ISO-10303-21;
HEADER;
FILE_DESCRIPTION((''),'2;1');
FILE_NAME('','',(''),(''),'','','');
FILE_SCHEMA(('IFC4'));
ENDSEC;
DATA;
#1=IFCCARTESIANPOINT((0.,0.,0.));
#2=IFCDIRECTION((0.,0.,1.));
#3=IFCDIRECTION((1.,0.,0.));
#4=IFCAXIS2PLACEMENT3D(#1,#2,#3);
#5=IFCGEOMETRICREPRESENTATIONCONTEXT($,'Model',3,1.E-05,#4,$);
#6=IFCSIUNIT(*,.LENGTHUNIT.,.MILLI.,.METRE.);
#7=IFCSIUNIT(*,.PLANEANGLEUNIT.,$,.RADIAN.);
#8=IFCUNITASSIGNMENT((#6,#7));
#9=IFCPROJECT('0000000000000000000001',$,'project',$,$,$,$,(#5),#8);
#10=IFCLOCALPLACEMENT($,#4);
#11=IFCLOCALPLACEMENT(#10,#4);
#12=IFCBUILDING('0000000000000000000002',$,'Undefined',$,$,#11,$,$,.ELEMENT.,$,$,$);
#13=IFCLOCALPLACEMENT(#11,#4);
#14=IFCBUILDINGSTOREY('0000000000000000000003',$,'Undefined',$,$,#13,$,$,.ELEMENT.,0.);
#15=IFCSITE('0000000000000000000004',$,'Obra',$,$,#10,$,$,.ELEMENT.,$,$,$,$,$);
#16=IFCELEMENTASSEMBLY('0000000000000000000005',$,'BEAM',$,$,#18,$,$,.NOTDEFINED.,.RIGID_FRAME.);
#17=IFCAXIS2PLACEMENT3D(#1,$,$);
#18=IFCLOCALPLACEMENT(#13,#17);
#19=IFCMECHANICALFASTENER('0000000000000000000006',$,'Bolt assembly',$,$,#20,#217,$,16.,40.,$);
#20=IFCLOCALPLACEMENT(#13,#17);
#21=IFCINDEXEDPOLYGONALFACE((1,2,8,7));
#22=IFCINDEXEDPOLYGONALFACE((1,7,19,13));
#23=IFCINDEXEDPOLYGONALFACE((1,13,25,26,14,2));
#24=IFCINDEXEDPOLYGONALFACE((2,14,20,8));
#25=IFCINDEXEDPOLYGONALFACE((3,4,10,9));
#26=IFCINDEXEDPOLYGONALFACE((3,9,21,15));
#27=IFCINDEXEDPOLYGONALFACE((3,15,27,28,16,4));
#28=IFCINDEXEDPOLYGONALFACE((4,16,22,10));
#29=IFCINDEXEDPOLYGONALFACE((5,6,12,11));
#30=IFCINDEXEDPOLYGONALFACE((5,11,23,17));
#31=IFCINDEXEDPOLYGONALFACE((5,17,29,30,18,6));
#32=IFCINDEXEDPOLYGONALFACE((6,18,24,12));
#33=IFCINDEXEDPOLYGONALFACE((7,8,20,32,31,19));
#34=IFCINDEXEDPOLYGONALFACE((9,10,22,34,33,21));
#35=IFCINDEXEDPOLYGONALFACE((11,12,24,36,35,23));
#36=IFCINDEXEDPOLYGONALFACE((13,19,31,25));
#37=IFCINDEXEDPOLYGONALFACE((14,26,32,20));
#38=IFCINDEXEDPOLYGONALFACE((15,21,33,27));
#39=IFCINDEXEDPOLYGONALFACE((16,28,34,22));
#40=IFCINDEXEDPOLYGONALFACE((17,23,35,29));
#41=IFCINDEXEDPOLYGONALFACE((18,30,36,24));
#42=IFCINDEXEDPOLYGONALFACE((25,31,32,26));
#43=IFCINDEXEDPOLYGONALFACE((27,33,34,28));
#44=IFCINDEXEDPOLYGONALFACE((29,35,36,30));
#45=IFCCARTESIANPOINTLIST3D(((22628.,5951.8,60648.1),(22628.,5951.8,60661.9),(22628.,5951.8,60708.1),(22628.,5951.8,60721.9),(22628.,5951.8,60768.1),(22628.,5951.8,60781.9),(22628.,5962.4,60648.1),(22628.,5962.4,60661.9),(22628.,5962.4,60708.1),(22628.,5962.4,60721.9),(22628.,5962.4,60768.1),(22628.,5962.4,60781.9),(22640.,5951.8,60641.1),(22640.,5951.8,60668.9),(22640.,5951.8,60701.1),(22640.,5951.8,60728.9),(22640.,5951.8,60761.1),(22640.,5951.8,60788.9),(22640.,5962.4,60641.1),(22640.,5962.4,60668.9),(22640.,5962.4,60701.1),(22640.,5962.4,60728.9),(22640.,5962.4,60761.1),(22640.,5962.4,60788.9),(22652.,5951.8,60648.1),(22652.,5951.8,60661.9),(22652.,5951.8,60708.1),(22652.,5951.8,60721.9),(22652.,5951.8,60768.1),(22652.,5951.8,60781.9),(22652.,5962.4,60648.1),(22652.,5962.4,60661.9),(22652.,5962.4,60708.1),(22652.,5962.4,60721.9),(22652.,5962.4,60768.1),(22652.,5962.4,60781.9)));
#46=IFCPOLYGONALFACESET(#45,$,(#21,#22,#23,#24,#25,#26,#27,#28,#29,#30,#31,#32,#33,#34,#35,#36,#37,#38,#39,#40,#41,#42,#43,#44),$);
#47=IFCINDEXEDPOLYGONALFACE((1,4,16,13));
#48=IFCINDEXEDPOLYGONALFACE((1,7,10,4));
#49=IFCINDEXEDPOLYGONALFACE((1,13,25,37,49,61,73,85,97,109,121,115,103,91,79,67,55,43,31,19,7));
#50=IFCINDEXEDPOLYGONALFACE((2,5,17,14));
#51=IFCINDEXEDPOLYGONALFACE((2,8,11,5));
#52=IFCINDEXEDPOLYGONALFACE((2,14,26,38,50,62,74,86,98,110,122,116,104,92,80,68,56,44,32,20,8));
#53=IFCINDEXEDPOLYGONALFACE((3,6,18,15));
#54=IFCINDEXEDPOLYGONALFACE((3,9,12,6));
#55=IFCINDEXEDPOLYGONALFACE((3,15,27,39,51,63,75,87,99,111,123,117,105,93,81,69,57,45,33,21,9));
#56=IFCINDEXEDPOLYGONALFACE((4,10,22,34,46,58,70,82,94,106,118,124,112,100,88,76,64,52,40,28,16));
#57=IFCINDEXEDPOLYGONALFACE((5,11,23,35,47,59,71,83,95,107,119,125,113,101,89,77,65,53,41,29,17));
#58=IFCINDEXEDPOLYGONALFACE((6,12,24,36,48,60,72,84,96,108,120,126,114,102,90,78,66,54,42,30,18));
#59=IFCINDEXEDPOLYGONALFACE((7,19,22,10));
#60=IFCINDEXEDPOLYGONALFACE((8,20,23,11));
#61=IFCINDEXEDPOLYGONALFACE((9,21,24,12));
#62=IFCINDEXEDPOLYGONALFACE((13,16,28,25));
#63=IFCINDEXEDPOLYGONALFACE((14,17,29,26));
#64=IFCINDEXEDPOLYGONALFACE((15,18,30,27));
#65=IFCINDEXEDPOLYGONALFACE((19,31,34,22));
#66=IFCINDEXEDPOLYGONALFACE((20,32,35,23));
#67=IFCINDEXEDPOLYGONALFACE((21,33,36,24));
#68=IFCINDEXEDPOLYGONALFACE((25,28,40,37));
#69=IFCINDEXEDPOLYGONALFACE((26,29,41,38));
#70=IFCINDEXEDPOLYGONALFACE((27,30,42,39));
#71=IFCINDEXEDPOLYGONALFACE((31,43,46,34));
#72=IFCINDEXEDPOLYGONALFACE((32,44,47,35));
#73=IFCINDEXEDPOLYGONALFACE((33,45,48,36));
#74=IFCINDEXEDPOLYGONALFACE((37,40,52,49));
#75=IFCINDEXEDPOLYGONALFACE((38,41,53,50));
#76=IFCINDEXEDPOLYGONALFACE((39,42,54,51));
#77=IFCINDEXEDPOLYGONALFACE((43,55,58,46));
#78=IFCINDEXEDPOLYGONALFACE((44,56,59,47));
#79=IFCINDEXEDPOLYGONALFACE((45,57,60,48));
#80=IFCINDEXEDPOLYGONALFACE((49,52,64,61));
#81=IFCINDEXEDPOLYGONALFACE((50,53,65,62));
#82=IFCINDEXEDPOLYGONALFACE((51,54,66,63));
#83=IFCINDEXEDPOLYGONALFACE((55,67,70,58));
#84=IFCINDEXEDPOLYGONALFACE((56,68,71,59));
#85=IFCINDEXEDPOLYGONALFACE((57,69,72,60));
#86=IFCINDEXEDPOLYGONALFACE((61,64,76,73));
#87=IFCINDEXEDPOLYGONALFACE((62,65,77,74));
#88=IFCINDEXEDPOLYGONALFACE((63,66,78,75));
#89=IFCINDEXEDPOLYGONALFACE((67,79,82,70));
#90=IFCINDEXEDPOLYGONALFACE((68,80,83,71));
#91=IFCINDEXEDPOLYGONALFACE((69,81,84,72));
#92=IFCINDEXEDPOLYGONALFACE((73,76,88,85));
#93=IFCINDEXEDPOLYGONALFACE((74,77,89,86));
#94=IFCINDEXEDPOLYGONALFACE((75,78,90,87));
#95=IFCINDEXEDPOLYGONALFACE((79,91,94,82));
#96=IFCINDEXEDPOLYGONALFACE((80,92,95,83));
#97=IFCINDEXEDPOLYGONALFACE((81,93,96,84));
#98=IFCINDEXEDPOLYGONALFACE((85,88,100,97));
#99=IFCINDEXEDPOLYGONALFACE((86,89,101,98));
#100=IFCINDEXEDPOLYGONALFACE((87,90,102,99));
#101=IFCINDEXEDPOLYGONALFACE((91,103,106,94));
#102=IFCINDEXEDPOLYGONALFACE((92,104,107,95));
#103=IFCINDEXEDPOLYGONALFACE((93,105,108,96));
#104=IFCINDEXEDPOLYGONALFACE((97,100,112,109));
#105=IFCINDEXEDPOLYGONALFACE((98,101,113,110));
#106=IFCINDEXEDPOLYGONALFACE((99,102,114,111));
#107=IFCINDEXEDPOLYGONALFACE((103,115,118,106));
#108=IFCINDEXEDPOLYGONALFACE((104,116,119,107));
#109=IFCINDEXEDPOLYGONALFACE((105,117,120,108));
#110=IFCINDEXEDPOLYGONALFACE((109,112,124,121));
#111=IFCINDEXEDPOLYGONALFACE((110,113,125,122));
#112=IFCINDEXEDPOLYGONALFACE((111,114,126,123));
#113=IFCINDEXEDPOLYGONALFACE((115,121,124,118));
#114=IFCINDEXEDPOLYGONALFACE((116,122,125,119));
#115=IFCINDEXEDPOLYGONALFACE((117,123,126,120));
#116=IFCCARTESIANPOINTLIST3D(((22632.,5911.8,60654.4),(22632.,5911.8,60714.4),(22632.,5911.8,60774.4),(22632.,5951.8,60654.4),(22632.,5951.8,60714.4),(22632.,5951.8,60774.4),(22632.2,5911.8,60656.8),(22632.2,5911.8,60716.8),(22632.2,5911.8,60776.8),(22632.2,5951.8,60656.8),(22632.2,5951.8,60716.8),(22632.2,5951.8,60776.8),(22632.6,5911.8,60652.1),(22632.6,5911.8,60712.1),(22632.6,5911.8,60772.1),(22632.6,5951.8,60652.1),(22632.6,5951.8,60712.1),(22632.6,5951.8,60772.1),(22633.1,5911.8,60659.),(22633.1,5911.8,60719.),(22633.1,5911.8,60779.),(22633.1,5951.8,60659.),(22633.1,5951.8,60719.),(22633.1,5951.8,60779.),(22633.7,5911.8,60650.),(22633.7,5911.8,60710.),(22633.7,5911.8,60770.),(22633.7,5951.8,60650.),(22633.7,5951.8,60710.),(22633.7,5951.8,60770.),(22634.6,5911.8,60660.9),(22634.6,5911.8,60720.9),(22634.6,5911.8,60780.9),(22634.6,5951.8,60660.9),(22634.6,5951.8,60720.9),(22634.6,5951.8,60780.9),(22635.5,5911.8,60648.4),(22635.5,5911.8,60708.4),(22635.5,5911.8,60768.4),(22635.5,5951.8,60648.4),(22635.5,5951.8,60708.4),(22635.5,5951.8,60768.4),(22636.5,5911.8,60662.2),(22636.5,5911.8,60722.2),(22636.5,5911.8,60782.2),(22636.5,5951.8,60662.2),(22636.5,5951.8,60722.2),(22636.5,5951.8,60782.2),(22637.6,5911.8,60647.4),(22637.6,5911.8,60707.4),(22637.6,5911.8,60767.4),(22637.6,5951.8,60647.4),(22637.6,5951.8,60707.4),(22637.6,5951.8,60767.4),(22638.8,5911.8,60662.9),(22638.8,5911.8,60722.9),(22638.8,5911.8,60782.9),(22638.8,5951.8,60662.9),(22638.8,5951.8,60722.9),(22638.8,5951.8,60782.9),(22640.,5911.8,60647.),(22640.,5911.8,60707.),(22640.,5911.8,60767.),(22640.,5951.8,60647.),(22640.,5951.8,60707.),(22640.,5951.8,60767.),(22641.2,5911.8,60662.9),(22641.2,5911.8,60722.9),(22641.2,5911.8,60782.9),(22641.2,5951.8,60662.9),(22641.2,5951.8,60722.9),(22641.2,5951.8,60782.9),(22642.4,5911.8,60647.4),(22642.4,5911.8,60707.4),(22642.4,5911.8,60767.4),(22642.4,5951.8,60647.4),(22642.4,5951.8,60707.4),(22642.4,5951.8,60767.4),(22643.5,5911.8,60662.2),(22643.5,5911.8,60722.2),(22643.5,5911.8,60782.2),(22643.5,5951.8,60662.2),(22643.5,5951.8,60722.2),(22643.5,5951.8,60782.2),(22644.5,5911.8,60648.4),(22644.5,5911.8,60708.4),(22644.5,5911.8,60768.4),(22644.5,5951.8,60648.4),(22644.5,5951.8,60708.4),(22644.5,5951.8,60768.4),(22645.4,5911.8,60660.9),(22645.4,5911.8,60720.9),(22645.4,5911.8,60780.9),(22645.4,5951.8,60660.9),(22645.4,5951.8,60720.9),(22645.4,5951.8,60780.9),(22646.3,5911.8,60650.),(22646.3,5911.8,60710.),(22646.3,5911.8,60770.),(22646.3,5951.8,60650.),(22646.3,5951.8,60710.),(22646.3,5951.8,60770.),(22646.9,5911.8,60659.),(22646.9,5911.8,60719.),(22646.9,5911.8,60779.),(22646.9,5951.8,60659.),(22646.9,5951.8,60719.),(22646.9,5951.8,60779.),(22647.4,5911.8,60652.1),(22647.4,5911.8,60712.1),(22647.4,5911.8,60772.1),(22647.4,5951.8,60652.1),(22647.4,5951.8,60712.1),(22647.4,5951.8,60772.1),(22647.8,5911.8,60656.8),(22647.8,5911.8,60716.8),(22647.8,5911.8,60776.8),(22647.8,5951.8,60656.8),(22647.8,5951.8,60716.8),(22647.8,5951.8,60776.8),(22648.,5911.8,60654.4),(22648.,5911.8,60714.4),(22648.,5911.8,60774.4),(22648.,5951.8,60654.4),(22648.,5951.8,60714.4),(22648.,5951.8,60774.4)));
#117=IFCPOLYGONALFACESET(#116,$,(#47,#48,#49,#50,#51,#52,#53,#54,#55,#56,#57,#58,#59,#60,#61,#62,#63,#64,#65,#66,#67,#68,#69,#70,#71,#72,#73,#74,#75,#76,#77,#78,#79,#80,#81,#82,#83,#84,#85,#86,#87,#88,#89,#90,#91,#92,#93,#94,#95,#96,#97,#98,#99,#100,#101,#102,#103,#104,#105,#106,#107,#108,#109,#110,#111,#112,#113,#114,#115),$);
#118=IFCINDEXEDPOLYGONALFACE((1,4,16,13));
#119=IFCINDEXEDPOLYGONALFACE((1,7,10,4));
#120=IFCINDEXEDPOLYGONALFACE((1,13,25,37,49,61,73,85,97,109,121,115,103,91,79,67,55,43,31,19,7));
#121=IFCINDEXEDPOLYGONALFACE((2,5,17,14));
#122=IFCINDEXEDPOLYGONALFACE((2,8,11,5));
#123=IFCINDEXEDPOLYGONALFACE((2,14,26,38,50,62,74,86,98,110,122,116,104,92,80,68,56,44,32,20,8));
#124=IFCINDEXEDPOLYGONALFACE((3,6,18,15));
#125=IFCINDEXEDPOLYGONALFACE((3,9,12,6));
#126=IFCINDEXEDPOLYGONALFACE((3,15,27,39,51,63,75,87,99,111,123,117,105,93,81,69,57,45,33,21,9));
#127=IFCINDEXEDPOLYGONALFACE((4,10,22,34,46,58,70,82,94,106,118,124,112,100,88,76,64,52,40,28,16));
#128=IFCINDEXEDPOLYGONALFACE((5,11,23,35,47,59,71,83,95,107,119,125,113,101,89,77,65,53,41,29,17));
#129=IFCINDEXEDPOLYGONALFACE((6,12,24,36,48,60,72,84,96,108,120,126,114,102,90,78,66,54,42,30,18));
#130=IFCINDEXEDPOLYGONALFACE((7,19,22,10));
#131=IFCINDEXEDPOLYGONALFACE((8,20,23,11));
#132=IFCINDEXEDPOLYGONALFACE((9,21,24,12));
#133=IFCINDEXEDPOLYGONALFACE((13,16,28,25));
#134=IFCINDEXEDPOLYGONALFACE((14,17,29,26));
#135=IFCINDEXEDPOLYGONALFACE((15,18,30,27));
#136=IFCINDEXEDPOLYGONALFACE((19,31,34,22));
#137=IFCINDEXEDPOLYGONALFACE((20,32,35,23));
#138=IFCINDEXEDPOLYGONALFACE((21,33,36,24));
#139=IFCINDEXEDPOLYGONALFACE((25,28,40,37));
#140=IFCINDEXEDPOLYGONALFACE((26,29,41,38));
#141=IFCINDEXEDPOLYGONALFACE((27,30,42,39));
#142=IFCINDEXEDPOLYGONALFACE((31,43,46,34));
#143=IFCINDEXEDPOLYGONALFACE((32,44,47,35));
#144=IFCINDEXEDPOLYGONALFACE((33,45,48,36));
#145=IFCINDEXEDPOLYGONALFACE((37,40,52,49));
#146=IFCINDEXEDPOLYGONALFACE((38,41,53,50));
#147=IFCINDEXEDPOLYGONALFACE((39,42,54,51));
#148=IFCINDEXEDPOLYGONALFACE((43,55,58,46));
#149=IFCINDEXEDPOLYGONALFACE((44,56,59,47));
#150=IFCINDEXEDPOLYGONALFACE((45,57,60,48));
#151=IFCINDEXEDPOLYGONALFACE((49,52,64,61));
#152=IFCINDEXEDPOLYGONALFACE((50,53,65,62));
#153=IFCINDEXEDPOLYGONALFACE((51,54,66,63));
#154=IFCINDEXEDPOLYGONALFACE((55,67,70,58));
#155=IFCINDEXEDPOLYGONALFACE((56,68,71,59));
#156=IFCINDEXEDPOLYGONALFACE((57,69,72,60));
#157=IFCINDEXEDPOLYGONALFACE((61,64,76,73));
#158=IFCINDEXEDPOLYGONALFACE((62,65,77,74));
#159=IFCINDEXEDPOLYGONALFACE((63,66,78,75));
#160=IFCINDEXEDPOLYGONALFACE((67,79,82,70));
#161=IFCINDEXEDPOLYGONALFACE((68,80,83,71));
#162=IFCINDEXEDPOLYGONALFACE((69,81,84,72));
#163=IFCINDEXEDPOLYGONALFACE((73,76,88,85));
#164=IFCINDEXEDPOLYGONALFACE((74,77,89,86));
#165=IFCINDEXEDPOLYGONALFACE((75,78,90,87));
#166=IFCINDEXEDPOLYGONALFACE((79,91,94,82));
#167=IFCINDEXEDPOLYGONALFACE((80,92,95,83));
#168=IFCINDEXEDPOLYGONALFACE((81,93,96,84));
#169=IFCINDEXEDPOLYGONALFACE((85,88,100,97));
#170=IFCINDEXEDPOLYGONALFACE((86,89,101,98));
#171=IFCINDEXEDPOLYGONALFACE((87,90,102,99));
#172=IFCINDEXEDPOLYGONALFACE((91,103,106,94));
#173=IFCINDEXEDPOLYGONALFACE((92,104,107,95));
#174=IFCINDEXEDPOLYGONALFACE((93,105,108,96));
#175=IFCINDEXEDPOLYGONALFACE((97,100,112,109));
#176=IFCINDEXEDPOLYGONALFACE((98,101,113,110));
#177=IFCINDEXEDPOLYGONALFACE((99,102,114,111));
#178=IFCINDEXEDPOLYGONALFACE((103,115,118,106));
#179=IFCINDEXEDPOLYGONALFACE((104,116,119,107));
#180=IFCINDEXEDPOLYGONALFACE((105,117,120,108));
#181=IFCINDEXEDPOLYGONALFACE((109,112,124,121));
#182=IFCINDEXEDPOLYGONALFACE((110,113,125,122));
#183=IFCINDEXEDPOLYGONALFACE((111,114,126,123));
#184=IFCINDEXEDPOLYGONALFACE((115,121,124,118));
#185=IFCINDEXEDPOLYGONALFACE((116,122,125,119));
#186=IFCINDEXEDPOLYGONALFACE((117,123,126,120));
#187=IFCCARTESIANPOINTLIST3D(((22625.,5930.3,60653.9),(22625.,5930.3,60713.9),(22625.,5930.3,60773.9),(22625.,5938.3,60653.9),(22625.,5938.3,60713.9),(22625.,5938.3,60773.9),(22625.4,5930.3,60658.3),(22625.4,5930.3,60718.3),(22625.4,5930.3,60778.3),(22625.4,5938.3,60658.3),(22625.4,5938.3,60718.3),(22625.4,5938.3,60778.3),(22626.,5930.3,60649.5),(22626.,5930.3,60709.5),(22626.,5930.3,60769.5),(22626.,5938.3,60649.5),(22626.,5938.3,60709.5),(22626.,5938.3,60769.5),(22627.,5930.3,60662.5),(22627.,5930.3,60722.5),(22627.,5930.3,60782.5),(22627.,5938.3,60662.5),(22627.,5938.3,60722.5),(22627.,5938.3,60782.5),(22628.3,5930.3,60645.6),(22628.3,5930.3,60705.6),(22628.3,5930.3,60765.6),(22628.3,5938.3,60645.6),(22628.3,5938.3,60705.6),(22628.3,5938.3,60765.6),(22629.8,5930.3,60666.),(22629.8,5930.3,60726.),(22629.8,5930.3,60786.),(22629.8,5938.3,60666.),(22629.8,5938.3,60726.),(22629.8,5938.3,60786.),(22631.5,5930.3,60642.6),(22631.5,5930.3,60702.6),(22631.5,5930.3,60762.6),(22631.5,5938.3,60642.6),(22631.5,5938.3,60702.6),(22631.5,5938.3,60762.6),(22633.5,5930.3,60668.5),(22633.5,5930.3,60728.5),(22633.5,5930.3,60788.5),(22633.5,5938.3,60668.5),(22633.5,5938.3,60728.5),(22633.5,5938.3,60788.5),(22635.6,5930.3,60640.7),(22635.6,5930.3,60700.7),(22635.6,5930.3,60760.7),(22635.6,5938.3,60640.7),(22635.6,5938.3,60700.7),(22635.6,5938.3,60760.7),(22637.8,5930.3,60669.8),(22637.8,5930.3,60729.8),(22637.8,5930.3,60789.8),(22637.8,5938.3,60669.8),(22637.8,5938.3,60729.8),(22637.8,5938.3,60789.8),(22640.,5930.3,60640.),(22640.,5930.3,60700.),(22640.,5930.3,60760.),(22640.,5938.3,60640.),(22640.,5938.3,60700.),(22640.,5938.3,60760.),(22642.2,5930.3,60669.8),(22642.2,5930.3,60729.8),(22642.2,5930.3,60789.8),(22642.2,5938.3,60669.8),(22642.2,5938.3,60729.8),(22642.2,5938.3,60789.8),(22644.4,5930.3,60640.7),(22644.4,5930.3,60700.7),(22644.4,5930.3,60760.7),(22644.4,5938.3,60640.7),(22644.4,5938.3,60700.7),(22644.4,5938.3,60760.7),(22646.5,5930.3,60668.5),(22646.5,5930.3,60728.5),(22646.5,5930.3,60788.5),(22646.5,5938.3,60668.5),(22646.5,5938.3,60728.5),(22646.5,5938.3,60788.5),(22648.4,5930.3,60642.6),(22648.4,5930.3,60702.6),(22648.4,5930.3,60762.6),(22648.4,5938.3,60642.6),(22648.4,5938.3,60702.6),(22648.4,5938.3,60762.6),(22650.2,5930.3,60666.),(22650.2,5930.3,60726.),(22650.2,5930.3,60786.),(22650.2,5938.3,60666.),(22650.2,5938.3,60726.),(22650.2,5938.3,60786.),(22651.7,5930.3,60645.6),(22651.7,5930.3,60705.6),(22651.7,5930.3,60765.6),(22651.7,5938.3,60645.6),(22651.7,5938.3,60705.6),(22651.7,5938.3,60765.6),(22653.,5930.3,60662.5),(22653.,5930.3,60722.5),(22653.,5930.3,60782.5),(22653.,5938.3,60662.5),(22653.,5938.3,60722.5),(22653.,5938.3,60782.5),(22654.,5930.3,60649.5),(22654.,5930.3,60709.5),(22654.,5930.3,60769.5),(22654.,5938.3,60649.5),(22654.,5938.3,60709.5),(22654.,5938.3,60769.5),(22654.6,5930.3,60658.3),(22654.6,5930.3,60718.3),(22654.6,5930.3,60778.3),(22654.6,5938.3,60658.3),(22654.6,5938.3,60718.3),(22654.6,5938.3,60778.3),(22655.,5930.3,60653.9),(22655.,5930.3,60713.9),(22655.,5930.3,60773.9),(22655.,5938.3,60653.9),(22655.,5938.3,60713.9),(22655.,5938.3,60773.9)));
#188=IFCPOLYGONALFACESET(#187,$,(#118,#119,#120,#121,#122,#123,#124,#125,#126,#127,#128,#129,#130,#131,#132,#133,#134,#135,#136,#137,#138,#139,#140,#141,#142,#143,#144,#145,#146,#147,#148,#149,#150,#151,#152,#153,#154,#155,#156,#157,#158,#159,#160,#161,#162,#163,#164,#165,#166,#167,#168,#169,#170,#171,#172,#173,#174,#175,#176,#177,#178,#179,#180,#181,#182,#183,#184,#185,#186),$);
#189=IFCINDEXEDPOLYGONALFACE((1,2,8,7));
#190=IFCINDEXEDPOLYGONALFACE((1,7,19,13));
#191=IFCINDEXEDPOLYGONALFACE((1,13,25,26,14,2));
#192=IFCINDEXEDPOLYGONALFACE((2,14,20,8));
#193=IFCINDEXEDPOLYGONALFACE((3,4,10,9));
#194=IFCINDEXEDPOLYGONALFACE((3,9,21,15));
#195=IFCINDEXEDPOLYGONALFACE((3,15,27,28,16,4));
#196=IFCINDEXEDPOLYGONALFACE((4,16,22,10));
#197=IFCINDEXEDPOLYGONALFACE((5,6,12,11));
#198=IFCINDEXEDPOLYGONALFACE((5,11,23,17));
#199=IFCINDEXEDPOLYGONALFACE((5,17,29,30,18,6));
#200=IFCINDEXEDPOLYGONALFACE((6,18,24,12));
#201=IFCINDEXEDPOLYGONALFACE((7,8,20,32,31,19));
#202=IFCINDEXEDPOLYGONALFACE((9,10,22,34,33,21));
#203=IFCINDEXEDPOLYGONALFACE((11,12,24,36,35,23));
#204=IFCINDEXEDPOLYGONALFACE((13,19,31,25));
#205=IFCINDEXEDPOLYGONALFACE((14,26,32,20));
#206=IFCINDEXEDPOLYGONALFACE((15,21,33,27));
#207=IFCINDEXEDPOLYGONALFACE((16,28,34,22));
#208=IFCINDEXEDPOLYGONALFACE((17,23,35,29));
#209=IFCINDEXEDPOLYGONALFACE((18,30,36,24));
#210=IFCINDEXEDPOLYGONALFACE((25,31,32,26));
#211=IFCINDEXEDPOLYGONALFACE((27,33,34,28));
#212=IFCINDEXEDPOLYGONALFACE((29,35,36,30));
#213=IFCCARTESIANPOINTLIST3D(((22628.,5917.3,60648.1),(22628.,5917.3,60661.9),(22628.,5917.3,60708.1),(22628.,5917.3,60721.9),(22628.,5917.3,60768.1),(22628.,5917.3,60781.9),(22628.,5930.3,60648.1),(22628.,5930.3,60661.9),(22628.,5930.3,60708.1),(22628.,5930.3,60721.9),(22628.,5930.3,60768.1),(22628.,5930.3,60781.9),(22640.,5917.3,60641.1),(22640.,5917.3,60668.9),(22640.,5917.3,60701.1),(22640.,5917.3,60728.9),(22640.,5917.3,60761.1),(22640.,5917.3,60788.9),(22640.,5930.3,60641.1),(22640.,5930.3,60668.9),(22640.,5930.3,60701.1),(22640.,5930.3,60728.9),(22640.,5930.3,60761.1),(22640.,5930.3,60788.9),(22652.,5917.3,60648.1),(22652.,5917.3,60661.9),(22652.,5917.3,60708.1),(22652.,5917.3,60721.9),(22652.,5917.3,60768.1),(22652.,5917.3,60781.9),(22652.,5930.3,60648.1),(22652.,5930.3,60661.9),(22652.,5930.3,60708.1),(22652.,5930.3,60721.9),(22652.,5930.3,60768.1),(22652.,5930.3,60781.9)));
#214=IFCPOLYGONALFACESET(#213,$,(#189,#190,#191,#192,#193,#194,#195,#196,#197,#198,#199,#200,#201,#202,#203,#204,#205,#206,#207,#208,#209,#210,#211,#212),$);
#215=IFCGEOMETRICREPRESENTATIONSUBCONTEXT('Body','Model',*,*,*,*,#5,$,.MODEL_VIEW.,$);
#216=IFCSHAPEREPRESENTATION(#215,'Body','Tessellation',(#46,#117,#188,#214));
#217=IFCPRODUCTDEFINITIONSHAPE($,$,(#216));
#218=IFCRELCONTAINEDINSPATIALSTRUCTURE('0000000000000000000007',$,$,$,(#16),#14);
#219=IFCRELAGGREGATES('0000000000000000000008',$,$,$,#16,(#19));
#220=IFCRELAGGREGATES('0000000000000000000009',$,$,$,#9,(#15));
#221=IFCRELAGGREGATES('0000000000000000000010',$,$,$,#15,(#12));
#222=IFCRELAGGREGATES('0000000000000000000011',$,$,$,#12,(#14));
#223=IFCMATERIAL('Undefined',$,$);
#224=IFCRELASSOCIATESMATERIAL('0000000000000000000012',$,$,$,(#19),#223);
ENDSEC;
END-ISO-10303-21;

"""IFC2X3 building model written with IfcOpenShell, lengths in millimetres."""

from ifc_helpers import new_model, si_unit, frame, origin_with_axes, origin_2d_with_axis, place, context, subcontext, project, spatial, polyline, circle, outline, extrude, source, transform, mapped, material, element, aggregate, save


model = new_model("IFC2X3")

# Units and contexts
model_context = context("Model", 3, precision=1e-05, world=origin_with_axes())
body_context = subcontext(model_context, "Body", "Model", "MODEL_VIEW")
ifc_project = project(units=[si_unit("LENGTHUNIT", "METRE", prefix="MILLI"), si_unit("PLANEANGLEUNIT", "RADIAN")], contexts=[model_context])

# Site, building, storey
site_placement = place(None, origin_with_axes())
site = spatial("IfcSite", under=ifc_project, at=site_placement, Name="Obra", CompositionType="ELEMENT")
building_placement = place(site_placement, origin_with_axes())
building = spatial("IfcBuilding", under=site, at=building_placement, Name="Undefined", CompositionType="ELEMENT")
storey_placement = place(building_placement, origin_with_axes())
storey = spatial("IfcBuildingStorey", under=building, at=storey_placement, Name="Undefined", CompositionType="ELEMENT", Elevation=0.0)

# Element assembly, mechanical fastener
ifc_material_1 = material(Name="Undefined")
assembly_1_placement = place(storey_placement, origin_with_axes())
assembly_1 = element("IfcElementAssembly", 1, at=assembly_1_placement, inside=storey, Name="BEAM", AssemblyPlace="NOTDEFINED", PredefinedType="RIGID_FRAME")
shared_shape_1 = source(origin_with_axes(), body_context, "Body", "SweptSolid", [
    extrude(outline(polyline([(13.9, 0.0), (6.9, 12.0), (-6.9, 12.0), (-13.9, 0.0), (-6.9, -12.0), (6.9, -12.0), (13.9, 0.0)])), frame((0.0, -19.7, 0.0), z_axis=(0.0, 1.0, 0.0), x_axis=(1.0, 0.0, 0.0)), (0.0, 0.0, 1.0), 10.6),
    extrude(circle(Radius=8.0, at=origin_2d_with_axis()), frame((0.0, -9.1, 0.0), z_axis=(0.0, 1.0, 0.0), x_axis=(1.0, 0.0, 0.0)), (0.0, 0.0, 1.0), 40.0),
    extrude(circle(Radius=15.0, at=origin_2d_with_axis()), frame((0.0, 4.4, 0.0), z_axis=(0.0, 1.0, 0.0), x_axis=(1.0, 0.0, 0.0)), (0.0, 0.0, 1.0), 8.0),
    extrude(outline(polyline([(13.9, 0.0), (6.9, 12.0), (-6.9, 12.0), (-13.9, 0.0), (-6.9, -12.0), (6.9, -12.0), (13.9, 0.0)])), frame((0.0, 12.4, 0.0), z_axis=(0.0, 1.0, 0.0), x_axis=(1.0, 0.0, 0.0)), (0.0, 0.0, 1.0), 13.0),
])
mechanical_fastener_1_placement = place(assembly_1_placement, frame((22690.0, 5942.7, 60835.0), z_axis=(-1.0, 0.0, 0.0), x_axis=(0.0, 0.0, -1.0)))
mechanical_fastener_1 = element("IfcMechanicalFastener", 2, at=mechanical_fastener_1_placement, material=ifc_material_1, Name="Bolt assembly", NominalDiameter=16.0, NominalLength=40.0, context=body_context, shape_type="MappedRepresentation", body=[
    mapped(shared_shape_1, transform((60.0, 0.0, 50.0))),
    mapped(shared_shape_1, transform((120.0, 0.0, 50.0))),
    mapped(shared_shape_1, transform((180.0, 0.0, 50.0))),
])
aggregate(assembly_1, [mechanical_fastener_1])

save(model, "model.ifc")
